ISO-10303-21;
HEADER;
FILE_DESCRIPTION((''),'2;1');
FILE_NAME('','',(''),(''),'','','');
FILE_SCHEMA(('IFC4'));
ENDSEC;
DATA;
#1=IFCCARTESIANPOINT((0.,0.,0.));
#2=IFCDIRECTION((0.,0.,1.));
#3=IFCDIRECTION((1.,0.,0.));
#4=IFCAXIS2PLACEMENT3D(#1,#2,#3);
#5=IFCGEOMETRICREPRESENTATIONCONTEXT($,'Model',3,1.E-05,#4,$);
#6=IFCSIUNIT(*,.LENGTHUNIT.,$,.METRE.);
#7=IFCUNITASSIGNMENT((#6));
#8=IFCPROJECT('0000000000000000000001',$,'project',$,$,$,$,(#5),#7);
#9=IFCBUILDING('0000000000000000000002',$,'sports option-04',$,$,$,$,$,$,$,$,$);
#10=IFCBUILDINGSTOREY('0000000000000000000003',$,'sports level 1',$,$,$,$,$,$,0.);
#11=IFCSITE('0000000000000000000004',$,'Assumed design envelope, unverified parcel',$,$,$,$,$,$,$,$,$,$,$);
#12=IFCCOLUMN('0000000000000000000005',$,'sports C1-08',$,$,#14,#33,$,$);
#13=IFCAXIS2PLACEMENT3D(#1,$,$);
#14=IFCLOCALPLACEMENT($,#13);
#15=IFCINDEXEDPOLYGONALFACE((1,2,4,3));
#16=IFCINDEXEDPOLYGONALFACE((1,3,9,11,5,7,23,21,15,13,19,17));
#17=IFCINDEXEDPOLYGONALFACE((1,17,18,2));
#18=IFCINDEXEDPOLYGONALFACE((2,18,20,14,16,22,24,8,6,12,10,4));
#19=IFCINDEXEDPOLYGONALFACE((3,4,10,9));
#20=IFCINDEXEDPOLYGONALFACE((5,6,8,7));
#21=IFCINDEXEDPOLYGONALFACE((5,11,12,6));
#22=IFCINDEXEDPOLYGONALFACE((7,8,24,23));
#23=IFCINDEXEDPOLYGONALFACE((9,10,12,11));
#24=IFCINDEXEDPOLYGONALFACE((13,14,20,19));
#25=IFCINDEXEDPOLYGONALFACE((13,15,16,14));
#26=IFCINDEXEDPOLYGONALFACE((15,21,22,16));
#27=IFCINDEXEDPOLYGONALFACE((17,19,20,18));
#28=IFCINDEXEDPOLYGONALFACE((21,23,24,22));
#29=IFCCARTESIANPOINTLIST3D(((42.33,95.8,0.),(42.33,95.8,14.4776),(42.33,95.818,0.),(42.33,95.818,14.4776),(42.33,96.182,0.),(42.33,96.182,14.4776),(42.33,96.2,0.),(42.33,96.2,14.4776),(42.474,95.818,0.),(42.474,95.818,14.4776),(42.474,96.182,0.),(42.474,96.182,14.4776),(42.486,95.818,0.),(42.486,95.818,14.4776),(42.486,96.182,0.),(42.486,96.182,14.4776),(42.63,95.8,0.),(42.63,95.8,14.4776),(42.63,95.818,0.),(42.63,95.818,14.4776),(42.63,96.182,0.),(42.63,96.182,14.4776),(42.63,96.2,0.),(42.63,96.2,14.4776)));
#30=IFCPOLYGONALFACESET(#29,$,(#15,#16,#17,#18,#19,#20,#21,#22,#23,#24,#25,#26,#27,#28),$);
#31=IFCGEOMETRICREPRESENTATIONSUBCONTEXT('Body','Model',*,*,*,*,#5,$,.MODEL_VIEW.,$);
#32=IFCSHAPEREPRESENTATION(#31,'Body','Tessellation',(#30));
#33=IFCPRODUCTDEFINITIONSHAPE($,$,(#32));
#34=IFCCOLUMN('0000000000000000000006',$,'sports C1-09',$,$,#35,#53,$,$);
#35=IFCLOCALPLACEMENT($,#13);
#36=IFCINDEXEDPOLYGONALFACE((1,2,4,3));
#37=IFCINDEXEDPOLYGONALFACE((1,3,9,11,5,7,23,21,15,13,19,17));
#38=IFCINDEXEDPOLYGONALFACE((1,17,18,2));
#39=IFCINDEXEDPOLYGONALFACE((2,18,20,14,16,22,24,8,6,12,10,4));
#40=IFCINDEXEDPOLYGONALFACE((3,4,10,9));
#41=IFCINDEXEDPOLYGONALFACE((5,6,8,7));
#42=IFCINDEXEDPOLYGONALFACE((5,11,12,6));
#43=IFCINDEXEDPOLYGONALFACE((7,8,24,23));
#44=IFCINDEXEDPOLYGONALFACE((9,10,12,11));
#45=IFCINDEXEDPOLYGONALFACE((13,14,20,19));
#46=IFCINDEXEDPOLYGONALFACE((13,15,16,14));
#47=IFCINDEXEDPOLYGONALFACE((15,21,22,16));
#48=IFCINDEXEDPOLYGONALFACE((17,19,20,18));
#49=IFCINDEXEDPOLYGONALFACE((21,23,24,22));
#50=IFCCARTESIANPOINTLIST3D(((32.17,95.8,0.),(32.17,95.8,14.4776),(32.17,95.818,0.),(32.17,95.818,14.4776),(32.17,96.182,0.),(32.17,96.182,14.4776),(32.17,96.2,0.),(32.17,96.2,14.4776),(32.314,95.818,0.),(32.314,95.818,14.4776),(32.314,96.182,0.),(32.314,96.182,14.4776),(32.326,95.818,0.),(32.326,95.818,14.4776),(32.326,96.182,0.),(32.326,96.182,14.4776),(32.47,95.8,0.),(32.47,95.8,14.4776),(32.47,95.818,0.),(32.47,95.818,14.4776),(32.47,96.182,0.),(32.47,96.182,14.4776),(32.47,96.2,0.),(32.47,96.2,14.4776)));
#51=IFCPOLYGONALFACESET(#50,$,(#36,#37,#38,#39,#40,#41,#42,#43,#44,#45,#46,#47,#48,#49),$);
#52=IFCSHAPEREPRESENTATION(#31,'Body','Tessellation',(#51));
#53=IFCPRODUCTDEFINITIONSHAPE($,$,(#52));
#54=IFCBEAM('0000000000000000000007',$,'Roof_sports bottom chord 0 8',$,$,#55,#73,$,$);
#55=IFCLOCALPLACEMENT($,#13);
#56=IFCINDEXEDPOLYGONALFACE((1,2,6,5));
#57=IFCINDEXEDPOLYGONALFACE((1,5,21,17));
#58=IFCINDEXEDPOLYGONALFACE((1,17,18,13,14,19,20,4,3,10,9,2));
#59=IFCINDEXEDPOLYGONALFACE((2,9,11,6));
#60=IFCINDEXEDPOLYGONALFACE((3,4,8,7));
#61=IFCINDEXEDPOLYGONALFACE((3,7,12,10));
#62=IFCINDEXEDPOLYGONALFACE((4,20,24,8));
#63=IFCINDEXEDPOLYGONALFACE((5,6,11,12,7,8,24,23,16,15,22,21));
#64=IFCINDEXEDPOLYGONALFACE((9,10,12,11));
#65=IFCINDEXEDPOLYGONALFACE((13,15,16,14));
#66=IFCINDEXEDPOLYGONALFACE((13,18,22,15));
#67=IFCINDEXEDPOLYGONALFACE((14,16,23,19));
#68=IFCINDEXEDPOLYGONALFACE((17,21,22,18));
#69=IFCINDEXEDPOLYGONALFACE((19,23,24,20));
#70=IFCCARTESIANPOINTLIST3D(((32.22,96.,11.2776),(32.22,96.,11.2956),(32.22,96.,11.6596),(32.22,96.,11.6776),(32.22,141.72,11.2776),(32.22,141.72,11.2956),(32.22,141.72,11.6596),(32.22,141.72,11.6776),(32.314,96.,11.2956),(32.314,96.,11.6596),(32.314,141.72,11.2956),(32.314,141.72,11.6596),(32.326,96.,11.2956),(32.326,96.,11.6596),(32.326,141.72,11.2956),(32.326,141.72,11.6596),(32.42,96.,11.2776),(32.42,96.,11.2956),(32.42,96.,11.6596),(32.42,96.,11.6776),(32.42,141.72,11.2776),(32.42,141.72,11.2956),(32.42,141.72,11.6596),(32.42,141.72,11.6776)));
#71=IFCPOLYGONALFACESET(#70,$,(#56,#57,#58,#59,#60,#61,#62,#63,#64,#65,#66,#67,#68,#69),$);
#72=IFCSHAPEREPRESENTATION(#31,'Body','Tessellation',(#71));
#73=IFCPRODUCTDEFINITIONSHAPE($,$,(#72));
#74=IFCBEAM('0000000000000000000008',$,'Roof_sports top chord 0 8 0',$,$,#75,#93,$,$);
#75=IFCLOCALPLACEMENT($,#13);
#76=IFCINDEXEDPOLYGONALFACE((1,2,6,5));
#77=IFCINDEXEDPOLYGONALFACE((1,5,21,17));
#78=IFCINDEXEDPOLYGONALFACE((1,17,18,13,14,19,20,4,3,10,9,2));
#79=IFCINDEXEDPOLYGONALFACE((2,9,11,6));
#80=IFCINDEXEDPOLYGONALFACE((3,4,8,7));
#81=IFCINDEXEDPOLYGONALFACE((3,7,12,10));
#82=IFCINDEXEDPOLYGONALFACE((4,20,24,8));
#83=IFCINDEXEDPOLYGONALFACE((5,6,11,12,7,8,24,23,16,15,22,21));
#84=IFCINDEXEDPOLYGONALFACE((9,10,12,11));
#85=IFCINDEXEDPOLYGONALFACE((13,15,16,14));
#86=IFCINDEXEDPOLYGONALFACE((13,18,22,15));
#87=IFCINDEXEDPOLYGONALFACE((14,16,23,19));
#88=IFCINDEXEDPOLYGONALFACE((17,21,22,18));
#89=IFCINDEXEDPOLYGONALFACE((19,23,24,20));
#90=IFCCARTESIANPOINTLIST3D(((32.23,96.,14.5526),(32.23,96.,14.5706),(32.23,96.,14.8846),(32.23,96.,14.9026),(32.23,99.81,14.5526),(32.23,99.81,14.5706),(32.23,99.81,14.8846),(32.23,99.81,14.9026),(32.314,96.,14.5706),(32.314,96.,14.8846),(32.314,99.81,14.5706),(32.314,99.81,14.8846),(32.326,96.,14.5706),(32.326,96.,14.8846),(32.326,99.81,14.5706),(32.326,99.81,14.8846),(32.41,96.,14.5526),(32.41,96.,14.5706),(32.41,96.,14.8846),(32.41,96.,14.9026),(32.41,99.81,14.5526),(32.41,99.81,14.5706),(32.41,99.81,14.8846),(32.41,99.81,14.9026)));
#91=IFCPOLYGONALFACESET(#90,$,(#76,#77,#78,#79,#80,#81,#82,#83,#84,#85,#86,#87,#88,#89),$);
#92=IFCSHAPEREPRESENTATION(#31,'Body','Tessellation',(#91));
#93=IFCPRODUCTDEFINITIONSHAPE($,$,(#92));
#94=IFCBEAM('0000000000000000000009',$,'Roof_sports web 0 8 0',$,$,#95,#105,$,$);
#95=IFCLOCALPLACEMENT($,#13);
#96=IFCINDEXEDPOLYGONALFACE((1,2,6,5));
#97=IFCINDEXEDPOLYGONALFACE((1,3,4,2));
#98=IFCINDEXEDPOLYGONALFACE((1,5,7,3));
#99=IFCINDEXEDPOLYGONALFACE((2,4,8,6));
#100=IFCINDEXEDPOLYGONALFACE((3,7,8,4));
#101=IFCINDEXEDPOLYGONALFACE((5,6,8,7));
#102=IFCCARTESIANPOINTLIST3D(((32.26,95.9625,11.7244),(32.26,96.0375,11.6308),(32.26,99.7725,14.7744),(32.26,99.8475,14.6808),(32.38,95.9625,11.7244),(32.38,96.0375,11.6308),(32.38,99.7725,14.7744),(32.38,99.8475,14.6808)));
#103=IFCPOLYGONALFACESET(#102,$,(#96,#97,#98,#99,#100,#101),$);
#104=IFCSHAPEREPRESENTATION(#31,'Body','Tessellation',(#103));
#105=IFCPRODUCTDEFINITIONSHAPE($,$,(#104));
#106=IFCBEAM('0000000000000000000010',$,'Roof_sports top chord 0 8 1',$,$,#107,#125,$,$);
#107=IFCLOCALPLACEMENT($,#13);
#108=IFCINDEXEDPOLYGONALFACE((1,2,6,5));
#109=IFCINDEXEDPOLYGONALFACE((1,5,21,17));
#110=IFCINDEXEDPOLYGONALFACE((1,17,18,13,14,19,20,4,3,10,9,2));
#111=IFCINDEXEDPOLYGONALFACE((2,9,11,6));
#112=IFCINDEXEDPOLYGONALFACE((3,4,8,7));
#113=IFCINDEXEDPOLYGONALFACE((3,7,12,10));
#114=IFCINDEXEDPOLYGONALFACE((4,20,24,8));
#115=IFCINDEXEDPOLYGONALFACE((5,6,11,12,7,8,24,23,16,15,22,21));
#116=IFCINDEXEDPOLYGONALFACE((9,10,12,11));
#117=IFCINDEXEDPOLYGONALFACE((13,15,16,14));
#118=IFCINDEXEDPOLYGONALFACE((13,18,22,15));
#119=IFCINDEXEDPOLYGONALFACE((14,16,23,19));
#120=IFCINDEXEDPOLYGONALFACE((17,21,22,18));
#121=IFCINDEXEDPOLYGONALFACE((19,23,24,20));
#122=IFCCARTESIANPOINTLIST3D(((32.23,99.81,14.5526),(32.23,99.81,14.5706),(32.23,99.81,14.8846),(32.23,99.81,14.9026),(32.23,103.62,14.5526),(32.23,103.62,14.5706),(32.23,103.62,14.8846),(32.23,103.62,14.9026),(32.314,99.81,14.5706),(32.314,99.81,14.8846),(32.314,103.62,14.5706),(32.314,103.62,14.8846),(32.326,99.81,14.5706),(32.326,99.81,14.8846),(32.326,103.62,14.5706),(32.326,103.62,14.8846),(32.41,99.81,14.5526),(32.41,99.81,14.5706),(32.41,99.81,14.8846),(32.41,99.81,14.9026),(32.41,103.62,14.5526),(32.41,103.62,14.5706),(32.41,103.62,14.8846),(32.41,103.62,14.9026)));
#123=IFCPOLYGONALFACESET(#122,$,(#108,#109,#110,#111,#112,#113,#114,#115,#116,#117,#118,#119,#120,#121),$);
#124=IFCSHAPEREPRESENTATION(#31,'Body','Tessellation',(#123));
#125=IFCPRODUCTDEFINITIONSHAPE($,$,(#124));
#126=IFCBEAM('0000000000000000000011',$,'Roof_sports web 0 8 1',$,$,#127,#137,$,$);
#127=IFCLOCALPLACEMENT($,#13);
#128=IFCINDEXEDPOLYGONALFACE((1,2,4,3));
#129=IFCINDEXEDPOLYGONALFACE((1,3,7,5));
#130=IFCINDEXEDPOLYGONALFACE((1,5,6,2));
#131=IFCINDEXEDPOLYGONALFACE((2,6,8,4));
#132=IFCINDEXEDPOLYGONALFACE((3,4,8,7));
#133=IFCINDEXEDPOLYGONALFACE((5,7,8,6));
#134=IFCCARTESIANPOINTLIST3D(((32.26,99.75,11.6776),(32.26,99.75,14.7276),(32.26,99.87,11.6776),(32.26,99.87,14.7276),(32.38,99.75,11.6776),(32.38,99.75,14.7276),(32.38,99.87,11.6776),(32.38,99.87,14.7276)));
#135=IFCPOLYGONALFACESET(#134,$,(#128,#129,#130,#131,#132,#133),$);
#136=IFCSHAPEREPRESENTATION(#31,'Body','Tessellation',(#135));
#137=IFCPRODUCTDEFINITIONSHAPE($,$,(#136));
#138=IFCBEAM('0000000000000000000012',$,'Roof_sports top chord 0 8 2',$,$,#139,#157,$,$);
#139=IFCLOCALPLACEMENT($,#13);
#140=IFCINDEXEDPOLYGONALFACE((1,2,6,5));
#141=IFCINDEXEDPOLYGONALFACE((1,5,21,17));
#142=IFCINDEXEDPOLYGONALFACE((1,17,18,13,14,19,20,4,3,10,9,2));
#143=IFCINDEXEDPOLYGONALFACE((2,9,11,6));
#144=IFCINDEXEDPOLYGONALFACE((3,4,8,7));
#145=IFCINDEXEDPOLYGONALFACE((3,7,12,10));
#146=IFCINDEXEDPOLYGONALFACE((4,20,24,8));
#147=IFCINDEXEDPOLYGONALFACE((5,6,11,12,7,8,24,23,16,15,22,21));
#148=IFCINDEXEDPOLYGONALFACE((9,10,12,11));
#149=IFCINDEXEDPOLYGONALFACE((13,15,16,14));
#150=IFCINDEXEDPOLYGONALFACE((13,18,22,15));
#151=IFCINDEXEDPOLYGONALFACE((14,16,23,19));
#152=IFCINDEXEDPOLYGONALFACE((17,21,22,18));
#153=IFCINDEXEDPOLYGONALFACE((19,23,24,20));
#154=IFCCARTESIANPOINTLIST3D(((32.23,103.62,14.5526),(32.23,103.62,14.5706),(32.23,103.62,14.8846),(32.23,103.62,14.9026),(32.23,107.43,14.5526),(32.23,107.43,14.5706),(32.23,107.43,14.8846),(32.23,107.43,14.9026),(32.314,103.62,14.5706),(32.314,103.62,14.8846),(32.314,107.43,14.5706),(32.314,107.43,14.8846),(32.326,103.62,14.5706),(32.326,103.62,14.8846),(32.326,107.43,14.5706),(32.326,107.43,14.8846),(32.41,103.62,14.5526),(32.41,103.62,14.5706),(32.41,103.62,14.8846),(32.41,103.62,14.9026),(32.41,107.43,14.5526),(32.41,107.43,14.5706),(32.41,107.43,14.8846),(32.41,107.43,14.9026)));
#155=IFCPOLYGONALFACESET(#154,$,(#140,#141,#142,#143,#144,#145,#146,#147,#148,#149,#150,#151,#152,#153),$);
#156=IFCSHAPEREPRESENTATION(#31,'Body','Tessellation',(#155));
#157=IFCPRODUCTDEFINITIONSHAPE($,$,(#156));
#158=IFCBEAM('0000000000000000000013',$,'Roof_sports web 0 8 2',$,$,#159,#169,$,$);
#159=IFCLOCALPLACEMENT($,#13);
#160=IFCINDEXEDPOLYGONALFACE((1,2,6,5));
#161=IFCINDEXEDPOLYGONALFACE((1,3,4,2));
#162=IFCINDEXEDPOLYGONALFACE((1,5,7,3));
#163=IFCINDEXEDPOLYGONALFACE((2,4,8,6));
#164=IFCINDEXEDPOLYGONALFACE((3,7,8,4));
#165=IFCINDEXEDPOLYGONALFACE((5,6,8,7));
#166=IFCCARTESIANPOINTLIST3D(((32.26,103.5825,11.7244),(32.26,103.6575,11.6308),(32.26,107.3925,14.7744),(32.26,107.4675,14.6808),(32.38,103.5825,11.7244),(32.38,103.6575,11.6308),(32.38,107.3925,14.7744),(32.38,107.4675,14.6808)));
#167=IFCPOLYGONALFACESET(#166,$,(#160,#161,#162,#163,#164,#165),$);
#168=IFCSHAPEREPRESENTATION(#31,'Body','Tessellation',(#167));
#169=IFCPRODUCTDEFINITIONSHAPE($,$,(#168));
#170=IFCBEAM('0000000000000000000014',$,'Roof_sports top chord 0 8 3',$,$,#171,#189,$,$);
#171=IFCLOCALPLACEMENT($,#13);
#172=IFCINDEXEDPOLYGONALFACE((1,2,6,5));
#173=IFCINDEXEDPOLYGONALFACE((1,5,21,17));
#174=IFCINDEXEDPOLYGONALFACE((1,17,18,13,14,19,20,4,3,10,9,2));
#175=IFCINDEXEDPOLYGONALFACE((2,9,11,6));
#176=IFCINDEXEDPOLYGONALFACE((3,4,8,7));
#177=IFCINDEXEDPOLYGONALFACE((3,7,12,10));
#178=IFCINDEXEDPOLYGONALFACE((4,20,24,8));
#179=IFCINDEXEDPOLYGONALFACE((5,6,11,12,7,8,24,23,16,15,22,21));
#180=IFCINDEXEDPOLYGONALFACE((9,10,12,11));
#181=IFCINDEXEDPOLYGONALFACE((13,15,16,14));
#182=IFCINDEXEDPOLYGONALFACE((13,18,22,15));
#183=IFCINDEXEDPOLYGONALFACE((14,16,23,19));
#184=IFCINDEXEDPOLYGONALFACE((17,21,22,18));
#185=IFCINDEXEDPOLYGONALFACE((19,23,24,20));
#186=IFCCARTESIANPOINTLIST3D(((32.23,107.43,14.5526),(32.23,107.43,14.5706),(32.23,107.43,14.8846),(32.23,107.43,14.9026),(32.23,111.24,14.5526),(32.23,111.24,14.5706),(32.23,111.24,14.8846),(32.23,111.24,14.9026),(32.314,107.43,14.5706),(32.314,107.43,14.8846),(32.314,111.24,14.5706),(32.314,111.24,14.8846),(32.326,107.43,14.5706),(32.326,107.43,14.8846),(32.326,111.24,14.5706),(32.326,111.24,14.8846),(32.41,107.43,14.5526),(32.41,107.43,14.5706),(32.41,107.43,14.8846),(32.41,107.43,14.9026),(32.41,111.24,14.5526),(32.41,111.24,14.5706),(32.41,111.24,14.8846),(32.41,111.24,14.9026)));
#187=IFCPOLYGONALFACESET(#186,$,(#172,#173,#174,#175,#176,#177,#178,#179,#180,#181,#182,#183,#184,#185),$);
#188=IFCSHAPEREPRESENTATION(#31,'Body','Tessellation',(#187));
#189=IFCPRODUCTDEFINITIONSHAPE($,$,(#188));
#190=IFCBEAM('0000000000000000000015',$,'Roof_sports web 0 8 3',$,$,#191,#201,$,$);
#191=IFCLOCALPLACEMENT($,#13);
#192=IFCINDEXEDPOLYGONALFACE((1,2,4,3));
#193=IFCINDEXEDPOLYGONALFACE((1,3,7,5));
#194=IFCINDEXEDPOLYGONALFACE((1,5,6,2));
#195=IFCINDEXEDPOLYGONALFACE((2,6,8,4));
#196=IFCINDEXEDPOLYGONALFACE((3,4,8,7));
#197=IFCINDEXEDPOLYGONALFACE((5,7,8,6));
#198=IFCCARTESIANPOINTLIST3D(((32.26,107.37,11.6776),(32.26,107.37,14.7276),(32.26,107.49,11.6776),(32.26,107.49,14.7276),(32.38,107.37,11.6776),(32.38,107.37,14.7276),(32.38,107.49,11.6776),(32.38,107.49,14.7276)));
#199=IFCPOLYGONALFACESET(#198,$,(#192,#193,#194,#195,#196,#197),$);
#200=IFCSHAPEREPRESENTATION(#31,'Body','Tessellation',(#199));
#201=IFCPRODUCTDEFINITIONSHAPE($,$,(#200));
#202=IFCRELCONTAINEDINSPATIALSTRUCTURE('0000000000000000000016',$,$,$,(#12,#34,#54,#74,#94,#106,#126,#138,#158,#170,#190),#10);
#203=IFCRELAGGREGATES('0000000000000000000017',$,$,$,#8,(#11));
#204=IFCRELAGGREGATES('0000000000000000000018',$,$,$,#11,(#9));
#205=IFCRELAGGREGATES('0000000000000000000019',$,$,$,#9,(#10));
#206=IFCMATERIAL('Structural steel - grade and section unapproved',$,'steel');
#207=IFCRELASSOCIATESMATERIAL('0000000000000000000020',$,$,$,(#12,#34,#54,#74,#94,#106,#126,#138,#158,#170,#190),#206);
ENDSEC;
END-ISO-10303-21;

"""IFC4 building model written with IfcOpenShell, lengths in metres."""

from ifc_helpers import new_model, si_unit, frame, origin_with_axes, place, context, subcontext, project, spatial, rectangle, i_section, extrude, material, element, save


model = new_model("IFC4")

# Units and contexts
model_context = context("Model", 3, precision=1e-05, world=origin_with_axes())
body_context = subcontext(model_context, "Body", "Model", "MODEL_VIEW")
ifc_project = project(units=[si_unit("LENGTHUNIT", "METRE")], contexts=[model_context])

# Site, building, storey
site = spatial("IfcSite", under=ifc_project, Name="Assumed design envelope, unverified parcel")
building = spatial("IfcBuilding", under=site, Name="sports option-04")
storey = spatial("IfcBuildingStorey", under=building, Name="sports level 1", Elevation=0.0)

# Columns
ifc_material_1 = material(Name="Structural steel - grade and section unapproved", Category="steel")
for number, where, z_axis, x_axis, name in (
    (1, (42.48, 96.0, 0.0), (0.0, 0.0, 1.0), (-1.0, 0.0, 0.0), "sports C1-08"),
    (2, (32.32, 96.0, 0.0), (0.0, 0.0, 1.0), (-1.0, 0.0, 0.0), "sports C1-09"),
):
    element("IfcColumn", number, at=place(None, frame(where, z_axis=z_axis, x_axis=x_axis)), inside=storey, material=ifc_material_1, Name=name, context=body_context, shape_type="SweptSolid", body=[
        extrude(i_section(OverallWidth=0.3, OverallDepth=0.4, WebThickness=0.012, FlangeThickness=0.018, FilletRadius=0.0), origin_with_axes(), (0.0, 0.0, 1.0), 14.4776),
    ])

# Beams
beam_1_placement = place(None, frame((32.32, 96.0, 11.4776), z_axis=(0.0, 1.0, 0.0), x_axis=(-1.0, 0.0, 0.0)))
element("IfcBeam", 3, at=beam_1_placement, inside=storey, material=ifc_material_1, Name="Roof_sports bottom chord 0 8", context=body_context, shape_type="SweptSolid", body=[
    extrude(i_section(OverallWidth=0.2, OverallDepth=0.4, WebThickness=0.012, FlangeThickness=0.018, FilletRadius=0.0), origin_with_axes(), (0.0, 0.0, 1.0), 45.72),
])
beam_2_placement = place(None, frame((32.32, 96.0, 14.7276), z_axis=(0.0, 1.0, 0.0), x_axis=(-1.0, 0.0, 0.0)))
element("IfcBeam", 4, at=beam_2_placement, inside=storey, material=ifc_material_1, Name="Roof_sports top chord 0 8 0", context=body_context, shape_type="SweptSolid", body=[
    extrude(i_section(OverallWidth=0.18, OverallDepth=0.35, WebThickness=0.012, FlangeThickness=0.018, FilletRadius=0.0), origin_with_axes(), (0.0, 0.0, 1.0), 3.81),
])
beam_3_placement = place(None, frame((32.32, 96.0, 11.6776), z_axis=(0.0, 0.780669, 0.624945), x_axis=(-1.0, 0.0, 0.0)))
element("IfcBeam", 5, at=beam_3_placement, inside=storey, material=ifc_material_1, Name="Roof_sports web 0 8 0", context=body_context, shape_type="SweptSolid", body=[
    extrude(rectangle(XDim=0.12, YDim=0.12), origin_with_axes(), (0.0, 0.0, 1.0), 4.8804),
])
beam_4_placement = place(None, frame((32.32, 99.81, 14.7276), z_axis=(0.0, 1.0, 0.0), x_axis=(-1.0, 0.0, 0.0)))
element("IfcBeam", 6, at=beam_4_placement, inside=storey, material=ifc_material_1, Name="Roof_sports top chord 0 8 1", context=body_context, shape_type="SweptSolid", body=[
    extrude(i_section(OverallWidth=0.18, OverallDepth=0.35, WebThickness=0.012, FlangeThickness=0.018, FilletRadius=0.0), origin_with_axes(), (0.0, 0.0, 1.0), 3.81),
])
beam_5_placement = place(None, frame((32.32, 99.81, 11.6776), z_axis=(0.0, 0.0, 1.0), x_axis=(-1.0, 0.0, 0.0)))
element("IfcBeam", 7, at=beam_5_placement, inside=storey, material=ifc_material_1, Name="Roof_sports web 0 8 1", context=body_context, shape_type="SweptSolid", body=[
    extrude(rectangle(XDim=0.12, YDim=0.12), origin_with_axes(), (0.0, 0.0, 1.0), 3.05),
])
beam_6_placement = place(None, frame((32.32, 103.62, 14.7276), z_axis=(0.0, 1.0, 0.0), x_axis=(-1.0, 0.0, 0.0)))
element("IfcBeam", 8, at=beam_6_placement, inside=storey, material=ifc_material_1, Name="Roof_sports top chord 0 8 2", context=body_context, shape_type="SweptSolid", body=[
    extrude(i_section(OverallWidth=0.18, OverallDepth=0.35, WebThickness=0.012, FlangeThickness=0.018, FilletRadius=0.0), origin_with_axes(), (0.0, 0.0, 1.0), 3.81),
])
beam_7_placement = place(None, frame((32.32, 103.62, 11.6776), z_axis=(0.0, 0.780669, 0.624945), x_axis=(-1.0, 0.0, 0.0)))
element("IfcBeam", 9, at=beam_7_placement, inside=storey, material=ifc_material_1, Name="Roof_sports web 0 8 2", context=body_context, shape_type="SweptSolid", body=[
    extrude(rectangle(XDim=0.12, YDim=0.12), origin_with_axes(), (0.0, 0.0, 1.0), 4.8804),
])
beam_8_placement = place(None, frame((32.32, 107.43, 14.7276), z_axis=(0.0, 1.0, 0.0), x_axis=(-1.0, 0.0, 0.0)))
element("IfcBeam", 10, at=beam_8_placement, inside=storey, material=ifc_material_1, Name="Roof_sports top chord 0 8 3", context=body_context, shape_type="SweptSolid", body=[
    extrude(i_section(OverallWidth=0.18, OverallDepth=0.35, WebThickness=0.012, FlangeThickness=0.018, FilletRadius=0.0), origin_with_axes(), (0.0, 0.0, 1.0), 3.81),
])
beam_9_placement = place(None, frame((32.32, 107.43, 11.6776), z_axis=(0.0, 0.0, 1.0), x_axis=(-1.0, 0.0, 0.0)))
element("IfcBeam", 11, at=beam_9_placement, inside=storey, material=ifc_material_1, Name="Roof_sports web 0 8 3", context=body_context, shape_type="SweptSolid", body=[
    extrude(rectangle(XDim=0.12, YDim=0.12), origin_with_axes(), (0.0, 0.0, 1.0), 3.05),
])

save(model, "model.ifc")
